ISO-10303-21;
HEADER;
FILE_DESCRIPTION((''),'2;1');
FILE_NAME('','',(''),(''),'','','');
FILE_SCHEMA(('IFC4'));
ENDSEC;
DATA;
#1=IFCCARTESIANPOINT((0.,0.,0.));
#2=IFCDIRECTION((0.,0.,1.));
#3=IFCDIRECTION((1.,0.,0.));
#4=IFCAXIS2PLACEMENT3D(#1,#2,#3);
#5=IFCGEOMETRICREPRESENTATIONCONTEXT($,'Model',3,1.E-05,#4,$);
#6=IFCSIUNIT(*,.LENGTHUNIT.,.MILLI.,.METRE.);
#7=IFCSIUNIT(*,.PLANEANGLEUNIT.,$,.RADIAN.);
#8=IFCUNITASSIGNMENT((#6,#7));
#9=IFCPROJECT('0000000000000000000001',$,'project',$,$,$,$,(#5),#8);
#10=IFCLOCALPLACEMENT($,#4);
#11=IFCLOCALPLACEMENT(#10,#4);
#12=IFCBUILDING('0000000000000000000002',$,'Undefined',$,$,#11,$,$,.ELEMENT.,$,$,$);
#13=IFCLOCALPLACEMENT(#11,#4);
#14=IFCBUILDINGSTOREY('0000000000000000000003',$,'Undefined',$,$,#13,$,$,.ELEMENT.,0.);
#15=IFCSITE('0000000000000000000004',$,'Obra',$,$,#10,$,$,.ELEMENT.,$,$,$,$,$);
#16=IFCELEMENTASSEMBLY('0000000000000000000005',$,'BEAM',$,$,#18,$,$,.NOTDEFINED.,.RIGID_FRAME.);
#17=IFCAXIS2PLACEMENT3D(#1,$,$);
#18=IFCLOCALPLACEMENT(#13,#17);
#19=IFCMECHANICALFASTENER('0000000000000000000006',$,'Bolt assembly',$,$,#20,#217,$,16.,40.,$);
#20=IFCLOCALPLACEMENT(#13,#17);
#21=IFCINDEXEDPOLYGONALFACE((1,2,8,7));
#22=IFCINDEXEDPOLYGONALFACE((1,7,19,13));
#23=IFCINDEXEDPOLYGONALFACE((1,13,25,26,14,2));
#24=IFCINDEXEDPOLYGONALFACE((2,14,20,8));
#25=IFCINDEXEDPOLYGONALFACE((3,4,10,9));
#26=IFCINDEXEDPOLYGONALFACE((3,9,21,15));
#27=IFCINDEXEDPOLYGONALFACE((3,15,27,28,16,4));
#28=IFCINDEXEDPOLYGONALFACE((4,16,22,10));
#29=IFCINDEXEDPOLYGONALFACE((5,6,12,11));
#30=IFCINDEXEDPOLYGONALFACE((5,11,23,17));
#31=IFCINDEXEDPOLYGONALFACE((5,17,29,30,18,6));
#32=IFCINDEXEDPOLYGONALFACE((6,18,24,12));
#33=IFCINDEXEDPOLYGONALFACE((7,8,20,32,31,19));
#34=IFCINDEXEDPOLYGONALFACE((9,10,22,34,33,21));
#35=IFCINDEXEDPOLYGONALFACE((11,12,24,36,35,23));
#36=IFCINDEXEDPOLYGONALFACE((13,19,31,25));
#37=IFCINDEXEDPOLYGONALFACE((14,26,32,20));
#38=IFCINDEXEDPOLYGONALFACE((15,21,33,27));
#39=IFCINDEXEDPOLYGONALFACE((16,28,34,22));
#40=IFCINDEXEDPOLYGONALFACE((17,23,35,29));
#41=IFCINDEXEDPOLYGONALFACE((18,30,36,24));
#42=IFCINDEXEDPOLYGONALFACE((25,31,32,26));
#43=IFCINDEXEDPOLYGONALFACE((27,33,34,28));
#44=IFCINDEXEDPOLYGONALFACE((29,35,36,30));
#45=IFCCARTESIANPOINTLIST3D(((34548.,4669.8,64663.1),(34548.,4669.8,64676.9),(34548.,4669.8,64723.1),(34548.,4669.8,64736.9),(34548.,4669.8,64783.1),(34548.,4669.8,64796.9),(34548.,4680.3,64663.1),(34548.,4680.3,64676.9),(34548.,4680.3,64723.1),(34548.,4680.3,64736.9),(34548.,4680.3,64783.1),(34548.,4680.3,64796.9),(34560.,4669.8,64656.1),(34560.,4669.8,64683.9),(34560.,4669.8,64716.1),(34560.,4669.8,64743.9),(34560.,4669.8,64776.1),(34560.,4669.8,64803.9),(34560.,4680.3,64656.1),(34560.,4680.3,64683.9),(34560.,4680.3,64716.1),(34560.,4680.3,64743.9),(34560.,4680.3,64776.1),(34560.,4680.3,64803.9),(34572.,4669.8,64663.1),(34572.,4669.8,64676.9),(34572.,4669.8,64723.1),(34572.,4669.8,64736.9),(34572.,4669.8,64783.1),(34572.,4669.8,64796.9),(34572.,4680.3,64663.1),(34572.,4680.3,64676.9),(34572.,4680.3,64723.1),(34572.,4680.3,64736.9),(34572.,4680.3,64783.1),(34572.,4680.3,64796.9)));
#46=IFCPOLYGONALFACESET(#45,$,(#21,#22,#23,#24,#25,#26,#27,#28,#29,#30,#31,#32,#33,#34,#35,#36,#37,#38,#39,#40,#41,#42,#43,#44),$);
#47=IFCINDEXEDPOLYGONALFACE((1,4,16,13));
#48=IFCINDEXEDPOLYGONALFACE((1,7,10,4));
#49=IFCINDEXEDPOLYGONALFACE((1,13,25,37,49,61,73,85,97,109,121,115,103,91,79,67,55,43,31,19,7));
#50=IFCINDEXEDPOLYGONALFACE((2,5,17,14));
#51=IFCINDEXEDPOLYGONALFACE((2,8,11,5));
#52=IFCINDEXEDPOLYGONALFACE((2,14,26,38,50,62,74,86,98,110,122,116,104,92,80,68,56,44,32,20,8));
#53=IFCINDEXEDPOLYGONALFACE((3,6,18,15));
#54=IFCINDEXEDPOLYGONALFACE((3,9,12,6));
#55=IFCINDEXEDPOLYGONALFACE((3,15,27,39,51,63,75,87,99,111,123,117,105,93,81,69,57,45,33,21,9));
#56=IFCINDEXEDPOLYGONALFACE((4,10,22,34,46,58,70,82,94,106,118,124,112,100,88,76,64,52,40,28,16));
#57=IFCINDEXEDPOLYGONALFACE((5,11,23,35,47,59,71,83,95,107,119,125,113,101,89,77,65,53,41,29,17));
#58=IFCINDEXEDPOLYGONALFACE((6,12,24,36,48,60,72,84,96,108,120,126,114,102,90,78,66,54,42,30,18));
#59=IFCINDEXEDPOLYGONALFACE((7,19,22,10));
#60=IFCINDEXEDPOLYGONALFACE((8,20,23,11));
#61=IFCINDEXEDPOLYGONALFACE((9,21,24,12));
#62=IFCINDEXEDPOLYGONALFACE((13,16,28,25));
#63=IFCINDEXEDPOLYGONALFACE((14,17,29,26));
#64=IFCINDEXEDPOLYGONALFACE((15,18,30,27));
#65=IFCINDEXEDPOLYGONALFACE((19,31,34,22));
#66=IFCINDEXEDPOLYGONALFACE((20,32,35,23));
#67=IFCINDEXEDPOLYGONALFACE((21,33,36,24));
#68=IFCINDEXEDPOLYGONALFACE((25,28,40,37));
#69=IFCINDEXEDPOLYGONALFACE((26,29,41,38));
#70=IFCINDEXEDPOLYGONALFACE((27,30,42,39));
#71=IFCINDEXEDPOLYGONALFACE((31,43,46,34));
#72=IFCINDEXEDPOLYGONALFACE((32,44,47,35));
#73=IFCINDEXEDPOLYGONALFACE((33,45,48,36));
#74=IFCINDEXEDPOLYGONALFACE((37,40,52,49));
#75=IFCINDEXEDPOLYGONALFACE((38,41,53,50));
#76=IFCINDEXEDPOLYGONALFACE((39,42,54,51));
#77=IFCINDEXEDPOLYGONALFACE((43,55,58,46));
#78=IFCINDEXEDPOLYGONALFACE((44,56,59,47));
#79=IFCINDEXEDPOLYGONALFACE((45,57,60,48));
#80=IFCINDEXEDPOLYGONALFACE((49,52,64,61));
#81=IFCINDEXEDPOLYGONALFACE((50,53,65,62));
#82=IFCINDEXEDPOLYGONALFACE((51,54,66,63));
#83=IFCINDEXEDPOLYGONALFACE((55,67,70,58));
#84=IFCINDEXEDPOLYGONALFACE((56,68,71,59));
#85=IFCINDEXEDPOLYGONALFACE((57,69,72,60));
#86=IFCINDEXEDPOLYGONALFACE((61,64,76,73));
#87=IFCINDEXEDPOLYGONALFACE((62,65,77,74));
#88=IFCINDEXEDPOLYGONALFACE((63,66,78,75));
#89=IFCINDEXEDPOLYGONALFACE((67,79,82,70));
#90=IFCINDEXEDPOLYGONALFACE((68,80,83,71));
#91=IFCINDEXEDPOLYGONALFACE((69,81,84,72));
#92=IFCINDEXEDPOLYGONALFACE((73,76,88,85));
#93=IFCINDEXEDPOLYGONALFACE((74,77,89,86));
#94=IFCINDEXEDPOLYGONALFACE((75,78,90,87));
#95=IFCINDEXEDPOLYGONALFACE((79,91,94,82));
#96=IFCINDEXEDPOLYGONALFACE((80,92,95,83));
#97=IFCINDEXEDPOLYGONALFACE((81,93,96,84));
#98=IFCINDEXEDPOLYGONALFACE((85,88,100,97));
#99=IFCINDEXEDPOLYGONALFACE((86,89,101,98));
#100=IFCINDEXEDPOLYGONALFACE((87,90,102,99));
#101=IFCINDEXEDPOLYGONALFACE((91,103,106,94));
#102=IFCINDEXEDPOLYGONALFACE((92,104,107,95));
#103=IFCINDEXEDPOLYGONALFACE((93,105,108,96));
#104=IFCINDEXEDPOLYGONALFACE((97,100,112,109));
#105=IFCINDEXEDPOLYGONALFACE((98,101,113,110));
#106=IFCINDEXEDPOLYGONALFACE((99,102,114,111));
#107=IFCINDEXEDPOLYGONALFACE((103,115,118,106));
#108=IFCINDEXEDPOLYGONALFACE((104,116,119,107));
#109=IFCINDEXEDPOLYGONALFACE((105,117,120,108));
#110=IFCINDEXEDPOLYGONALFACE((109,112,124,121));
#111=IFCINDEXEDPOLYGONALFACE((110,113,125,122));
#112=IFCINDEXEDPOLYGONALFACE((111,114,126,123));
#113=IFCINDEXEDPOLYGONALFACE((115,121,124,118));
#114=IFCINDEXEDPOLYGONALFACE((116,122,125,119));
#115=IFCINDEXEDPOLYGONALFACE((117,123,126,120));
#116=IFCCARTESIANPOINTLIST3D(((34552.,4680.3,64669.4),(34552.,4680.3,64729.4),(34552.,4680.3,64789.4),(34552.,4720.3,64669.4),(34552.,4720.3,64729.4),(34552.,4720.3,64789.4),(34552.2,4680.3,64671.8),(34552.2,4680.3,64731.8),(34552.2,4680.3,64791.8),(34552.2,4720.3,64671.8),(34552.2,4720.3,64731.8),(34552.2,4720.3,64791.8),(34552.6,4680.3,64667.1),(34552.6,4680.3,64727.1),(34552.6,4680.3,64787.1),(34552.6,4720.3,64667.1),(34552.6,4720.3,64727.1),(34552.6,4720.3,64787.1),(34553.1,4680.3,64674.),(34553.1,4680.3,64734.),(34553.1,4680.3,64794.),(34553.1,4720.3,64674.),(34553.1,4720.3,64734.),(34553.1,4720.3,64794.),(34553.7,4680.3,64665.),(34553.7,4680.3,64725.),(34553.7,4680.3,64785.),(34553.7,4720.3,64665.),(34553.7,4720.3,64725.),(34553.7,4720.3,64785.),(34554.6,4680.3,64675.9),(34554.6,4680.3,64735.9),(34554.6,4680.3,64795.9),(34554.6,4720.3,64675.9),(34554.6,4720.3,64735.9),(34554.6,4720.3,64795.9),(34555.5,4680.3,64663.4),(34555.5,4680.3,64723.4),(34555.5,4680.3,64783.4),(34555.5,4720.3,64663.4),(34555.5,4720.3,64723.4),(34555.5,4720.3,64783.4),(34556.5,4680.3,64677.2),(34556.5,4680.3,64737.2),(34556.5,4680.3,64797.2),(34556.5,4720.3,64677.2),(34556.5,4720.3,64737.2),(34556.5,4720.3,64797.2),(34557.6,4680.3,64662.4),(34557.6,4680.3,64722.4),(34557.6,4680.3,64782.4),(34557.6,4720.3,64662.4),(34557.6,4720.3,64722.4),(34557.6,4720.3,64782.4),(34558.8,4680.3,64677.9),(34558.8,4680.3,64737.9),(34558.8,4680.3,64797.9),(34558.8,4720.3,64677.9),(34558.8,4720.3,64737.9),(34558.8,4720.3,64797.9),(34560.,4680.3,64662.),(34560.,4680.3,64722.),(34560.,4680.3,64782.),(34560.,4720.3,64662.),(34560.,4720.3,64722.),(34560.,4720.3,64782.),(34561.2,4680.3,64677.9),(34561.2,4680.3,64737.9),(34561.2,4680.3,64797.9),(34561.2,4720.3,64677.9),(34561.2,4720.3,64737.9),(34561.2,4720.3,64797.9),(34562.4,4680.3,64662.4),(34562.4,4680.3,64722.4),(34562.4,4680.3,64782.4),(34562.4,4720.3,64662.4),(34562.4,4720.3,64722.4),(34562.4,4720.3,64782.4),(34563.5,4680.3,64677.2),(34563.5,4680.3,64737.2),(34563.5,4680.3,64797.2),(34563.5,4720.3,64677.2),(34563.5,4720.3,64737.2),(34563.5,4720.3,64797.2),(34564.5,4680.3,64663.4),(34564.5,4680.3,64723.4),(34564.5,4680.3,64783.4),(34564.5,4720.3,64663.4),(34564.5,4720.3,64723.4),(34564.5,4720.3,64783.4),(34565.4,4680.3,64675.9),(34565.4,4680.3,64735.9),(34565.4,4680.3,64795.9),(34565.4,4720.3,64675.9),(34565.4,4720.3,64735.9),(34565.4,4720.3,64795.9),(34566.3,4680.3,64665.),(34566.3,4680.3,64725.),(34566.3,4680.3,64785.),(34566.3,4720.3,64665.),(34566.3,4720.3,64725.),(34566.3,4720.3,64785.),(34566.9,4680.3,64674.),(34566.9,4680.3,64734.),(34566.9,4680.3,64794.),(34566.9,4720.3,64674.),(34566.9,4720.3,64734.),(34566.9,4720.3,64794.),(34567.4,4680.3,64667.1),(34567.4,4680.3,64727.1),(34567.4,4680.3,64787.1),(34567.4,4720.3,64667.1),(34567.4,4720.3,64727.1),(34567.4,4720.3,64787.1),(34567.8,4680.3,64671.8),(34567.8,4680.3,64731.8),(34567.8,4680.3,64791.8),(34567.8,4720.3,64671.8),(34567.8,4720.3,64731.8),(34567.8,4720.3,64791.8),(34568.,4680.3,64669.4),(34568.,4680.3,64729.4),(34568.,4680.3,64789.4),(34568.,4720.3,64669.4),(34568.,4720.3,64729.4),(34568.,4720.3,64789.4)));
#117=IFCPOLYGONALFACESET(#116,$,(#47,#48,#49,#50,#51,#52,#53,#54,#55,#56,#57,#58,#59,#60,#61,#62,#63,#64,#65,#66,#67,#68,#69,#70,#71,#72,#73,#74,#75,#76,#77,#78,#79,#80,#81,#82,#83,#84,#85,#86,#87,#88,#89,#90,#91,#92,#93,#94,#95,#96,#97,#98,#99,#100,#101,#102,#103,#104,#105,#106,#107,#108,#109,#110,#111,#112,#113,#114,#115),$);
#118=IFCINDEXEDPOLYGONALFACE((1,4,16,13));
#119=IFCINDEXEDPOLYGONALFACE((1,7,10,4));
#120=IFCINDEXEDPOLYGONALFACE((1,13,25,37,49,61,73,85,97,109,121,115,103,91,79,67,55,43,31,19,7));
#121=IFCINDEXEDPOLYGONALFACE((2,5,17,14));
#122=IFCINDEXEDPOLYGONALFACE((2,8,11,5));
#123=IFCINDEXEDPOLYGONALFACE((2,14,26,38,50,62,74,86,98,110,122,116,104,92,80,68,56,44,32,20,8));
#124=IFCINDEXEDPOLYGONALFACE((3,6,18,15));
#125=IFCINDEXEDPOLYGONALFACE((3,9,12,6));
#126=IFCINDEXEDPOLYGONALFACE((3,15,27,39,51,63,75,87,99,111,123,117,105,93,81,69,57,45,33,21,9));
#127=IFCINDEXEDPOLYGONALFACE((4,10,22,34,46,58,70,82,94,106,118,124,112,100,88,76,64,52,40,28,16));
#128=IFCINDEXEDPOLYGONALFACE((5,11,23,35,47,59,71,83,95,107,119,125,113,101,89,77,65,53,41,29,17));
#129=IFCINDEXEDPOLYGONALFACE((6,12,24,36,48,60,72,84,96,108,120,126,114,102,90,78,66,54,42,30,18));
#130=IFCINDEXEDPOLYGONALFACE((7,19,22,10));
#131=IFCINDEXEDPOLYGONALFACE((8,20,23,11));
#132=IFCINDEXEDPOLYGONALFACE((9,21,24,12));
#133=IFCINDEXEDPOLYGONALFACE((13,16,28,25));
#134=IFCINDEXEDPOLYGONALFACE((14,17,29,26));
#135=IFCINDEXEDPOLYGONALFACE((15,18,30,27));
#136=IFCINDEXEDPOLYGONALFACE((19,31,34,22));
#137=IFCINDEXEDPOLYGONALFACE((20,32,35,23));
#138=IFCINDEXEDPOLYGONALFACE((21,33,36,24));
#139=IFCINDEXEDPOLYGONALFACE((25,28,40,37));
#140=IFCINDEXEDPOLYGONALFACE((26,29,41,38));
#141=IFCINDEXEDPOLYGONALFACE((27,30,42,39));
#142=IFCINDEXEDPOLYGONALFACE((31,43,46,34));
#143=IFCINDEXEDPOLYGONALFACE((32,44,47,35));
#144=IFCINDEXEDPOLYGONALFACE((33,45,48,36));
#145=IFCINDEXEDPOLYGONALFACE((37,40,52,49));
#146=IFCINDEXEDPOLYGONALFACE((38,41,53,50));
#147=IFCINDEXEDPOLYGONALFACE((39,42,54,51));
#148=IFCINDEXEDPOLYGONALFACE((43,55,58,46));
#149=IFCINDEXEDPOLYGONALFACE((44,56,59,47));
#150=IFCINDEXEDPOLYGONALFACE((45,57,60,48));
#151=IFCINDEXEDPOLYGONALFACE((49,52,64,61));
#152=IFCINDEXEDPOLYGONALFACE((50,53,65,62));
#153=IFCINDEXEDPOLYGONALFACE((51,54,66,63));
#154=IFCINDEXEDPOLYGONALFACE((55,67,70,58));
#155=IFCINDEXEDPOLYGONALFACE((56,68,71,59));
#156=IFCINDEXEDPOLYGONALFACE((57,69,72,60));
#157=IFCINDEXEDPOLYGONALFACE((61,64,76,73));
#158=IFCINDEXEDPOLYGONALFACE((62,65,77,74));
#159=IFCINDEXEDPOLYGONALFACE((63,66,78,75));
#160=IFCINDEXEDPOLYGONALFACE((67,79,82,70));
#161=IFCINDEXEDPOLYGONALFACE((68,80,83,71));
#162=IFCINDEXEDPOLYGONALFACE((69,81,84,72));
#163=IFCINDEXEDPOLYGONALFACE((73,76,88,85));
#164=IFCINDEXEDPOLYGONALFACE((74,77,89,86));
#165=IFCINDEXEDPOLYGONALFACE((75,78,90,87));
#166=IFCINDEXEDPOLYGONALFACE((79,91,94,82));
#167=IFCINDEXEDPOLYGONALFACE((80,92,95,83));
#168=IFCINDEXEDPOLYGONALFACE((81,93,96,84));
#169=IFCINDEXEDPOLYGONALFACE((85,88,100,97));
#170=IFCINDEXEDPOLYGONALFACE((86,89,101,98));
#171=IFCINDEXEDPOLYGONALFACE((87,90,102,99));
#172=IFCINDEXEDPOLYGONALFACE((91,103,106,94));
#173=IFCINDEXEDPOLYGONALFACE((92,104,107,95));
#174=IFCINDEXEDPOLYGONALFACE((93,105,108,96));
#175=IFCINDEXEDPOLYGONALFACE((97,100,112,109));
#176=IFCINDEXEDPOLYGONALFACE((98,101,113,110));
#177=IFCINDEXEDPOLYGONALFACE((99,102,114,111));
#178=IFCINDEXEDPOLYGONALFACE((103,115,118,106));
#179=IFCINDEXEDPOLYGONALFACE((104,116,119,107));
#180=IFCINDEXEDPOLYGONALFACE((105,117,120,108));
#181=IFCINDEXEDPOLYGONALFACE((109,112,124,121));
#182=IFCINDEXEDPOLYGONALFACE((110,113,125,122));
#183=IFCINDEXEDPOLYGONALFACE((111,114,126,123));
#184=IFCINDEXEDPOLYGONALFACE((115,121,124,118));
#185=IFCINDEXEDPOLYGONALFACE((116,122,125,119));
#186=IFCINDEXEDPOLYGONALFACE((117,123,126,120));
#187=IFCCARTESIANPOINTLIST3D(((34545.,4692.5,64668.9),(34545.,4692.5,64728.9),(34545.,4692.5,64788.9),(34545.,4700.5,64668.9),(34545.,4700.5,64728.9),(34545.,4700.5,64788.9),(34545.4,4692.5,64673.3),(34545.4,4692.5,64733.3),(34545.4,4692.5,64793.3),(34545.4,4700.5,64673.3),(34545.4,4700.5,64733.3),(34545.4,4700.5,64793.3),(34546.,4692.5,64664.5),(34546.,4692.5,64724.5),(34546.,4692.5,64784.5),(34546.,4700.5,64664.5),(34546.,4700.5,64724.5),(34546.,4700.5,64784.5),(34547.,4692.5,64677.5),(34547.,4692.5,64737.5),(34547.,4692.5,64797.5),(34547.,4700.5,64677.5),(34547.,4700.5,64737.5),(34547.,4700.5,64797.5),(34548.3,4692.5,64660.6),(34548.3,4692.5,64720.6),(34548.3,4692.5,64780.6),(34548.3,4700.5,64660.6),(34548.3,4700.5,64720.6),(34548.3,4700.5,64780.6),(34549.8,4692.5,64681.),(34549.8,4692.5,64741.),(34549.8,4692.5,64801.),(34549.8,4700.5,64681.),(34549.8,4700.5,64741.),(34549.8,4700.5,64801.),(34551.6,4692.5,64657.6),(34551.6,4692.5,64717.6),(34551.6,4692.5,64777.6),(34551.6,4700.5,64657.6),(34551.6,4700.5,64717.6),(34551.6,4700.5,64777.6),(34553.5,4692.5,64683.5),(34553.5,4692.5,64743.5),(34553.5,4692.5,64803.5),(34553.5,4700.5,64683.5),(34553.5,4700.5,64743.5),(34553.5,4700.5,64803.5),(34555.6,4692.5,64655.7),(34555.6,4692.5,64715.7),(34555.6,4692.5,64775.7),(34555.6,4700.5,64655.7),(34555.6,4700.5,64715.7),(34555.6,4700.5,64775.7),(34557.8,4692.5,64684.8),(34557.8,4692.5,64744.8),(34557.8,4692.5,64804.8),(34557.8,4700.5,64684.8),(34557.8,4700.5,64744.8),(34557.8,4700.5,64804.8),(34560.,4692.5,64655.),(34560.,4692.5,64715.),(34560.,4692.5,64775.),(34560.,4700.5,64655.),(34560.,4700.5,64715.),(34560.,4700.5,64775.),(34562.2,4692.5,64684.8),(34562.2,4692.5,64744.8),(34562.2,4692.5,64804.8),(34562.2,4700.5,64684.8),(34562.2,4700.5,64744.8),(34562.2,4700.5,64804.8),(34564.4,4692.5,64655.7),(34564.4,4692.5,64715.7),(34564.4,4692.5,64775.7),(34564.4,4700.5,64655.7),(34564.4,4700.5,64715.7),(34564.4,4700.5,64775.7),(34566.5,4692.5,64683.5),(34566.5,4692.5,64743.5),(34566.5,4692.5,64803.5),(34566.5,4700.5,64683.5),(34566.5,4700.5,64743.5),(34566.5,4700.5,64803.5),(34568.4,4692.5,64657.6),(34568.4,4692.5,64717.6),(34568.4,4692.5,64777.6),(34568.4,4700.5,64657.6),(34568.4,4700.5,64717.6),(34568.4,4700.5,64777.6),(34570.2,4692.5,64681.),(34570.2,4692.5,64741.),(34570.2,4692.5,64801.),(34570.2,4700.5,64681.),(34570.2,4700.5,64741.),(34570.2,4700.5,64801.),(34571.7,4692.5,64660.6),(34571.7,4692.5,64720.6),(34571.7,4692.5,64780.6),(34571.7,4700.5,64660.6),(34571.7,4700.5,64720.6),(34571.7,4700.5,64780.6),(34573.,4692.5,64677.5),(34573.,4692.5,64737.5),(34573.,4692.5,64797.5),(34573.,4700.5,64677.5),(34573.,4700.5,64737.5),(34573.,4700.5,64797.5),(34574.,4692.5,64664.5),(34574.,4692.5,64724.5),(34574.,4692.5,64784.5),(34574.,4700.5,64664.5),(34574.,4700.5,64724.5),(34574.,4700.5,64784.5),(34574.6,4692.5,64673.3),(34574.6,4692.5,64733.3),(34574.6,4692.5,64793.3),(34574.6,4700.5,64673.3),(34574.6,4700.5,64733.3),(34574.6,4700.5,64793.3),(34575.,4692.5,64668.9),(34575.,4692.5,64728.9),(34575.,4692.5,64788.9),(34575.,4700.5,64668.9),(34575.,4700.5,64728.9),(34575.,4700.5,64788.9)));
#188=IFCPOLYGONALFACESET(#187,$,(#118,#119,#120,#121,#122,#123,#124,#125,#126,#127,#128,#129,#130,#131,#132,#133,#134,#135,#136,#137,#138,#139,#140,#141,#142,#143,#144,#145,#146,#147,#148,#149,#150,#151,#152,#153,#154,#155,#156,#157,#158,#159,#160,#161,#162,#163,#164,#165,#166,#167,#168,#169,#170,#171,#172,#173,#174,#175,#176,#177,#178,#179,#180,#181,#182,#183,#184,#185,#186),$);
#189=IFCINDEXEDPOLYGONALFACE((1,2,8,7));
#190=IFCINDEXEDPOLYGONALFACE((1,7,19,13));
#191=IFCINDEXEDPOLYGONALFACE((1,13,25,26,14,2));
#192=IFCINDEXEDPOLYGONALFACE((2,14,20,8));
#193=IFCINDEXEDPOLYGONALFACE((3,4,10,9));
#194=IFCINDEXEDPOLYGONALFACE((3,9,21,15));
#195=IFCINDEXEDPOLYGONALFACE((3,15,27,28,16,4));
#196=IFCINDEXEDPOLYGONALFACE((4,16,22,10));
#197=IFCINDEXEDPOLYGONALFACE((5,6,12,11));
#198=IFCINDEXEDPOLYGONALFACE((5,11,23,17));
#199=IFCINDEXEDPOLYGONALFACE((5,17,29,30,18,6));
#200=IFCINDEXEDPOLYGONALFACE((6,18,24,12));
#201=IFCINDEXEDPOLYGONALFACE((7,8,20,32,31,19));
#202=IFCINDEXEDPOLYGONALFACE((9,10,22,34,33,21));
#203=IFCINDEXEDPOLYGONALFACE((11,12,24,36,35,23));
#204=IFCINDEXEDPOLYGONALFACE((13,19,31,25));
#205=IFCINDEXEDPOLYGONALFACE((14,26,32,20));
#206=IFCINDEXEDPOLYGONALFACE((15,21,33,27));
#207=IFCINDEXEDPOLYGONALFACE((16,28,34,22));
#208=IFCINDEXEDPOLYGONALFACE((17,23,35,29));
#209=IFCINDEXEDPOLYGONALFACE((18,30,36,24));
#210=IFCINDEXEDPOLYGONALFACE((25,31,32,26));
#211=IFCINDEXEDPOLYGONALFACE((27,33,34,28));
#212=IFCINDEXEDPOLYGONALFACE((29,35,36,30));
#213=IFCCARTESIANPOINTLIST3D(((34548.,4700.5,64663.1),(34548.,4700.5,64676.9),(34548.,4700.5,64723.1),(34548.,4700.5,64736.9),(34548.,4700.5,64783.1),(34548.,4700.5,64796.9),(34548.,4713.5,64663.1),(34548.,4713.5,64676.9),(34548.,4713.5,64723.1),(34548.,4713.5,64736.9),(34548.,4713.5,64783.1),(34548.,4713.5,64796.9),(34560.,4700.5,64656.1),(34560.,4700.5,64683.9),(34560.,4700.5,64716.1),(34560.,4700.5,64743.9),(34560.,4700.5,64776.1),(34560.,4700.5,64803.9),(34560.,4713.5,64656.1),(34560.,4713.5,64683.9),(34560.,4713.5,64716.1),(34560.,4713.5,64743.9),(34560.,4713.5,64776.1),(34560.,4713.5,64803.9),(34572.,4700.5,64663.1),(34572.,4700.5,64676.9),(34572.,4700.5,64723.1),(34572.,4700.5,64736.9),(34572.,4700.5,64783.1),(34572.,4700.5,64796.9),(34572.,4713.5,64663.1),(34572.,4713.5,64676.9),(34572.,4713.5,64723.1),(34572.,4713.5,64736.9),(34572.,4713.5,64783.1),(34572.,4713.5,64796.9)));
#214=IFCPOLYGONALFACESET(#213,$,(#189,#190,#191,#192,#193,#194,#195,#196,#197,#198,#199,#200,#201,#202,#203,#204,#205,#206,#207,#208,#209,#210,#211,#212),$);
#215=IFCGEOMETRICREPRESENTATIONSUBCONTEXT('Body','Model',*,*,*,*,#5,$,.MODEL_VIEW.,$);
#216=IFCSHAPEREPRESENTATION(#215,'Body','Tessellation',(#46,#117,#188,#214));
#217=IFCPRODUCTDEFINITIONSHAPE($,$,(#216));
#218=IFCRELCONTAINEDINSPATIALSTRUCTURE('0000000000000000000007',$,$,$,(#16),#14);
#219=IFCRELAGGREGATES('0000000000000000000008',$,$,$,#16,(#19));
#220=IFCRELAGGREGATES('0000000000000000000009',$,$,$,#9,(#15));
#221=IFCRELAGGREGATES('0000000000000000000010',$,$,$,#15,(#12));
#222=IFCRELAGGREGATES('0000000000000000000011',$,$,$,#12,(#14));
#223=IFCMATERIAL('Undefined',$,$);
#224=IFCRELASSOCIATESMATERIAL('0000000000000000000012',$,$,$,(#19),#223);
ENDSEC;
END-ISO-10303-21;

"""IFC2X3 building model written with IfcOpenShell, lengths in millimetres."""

from ifc_helpers import new_model, si_unit, frame, origin_with_axes, origin_2d_with_axis, place, context, subcontext, project, spatial, polyline, circle, outline, extrude, source, transform, mapped, material, element, aggregate, save


model = new_model("IFC2X3")

# Units and contexts
model_context = context("Model", 3, precision=1e-05, world=origin_with_axes())
body_context = subcontext(model_context, "Body", "Model", "MODEL_VIEW")
ifc_project = project(units=[si_unit("LENGTHUNIT", "METRE", prefix="MILLI"), si_unit("PLANEANGLEUNIT", "RADIAN")], contexts=[model_context])

# Site, building, storey
site_placement = place(None, origin_with_axes())
site = spatial("IfcSite", under=ifc_project, at=site_placement, Name="Obra", CompositionType="ELEMENT")
building_placement = place(site_placement, origin_with_axes())
building = spatial("IfcBuilding", under=site, at=building_placement, Name="Undefined", CompositionType="ELEMENT")
storey_placement = place(building_placement, origin_with_axes())
storey = spatial("IfcBuildingStorey", under=building, at=storey_placement, Name="Undefined", CompositionType="ELEMENT", Elevation=0.0)

# Shared definitions
ifc_material = material(Name="Undefined")

# Element assembly
assembly_1_placement = place(storey_placement, origin_with_axes())
assembly_1 = element("IfcElementAssembly", 1, at=assembly_1_placement, inside=storey, Name="BEAM", AssemblyPlace="NOTDEFINED", PredefinedType="RIGID_FRAME")

# Mechanical fastener
shared_shape_1 = source(origin_with_axes(), body_context, "Body", "SweptSolid", [
    extrude(outline(polyline([(13.9, 0.0), (6.9, 12.0), (-6.9, 12.0), (-13.9, 0.0), (-6.9, -12.0), (6.9, -12.0), (13.9, 0.0)])), frame((0.0, -19.7, 0.0), z_axis=(0.0, 1.0, 0.0), x_axis=(1.0, 0.0, 0.0)), (0.0, 0.0, 1.0), 10.6),
    extrude(circle(Radius=8.0, at=origin_2d_with_axis()), frame((0.0, -9.1, 0.0), z_axis=(0.0, 1.0, 0.0), x_axis=(1.0, 0.0, 0.0)), (0.0, 0.0, 1.0), 40.0),
    extrude(circle(Radius=15.0, at=origin_2d_with_axis()), frame((0.0, 3.1, 0.0), z_axis=(0.0, 1.0, 0.0), x_axis=(1.0, 0.0, 0.0)), (0.0, 0.0, 1.0), 8.0),
    extrude(outline(polyline([(13.9, 0.0), (6.9, 12.0), (-6.9, 12.0), (-13.9, 0.0), (-6.9, -12.0), (6.9, -12.0), (13.9, 0.0)])), frame((0.0, 11.1, 0.0), z_axis=(0.0, 1.0, 0.0), x_axis=(1.0, 0.0, 0.0)), (0.0, 0.0, 1.0), 13.0),
])
mechanical_fastener_1_placement = place(assembly_1_placement, frame((34510.0, 4689.4, 64850.0), z_axis=(1.0, 0.0, 0.0), x_axis=(0.0, 0.0, -1.0)))
mechanical_fastener_1 = element("IfcMechanicalFastener", 2, at=mechanical_fastener_1_placement, material=ifc_material, Name="Bolt assembly", NominalDiameter=16.0, NominalLength=40.0, context=body_context, shape_type="MappedRepresentation", body=[
    mapped(shared_shape_1, transform((60.0, 0.0, 50.0))),
    mapped(shared_shape_1, transform((120.0, 0.0, 50.0))),
    mapped(shared_shape_1, transform((180.0, 0.0, 50.0))),
])
aggregate(assembly_1, [mechanical_fastener_1])

save(model, "model.ifc")
